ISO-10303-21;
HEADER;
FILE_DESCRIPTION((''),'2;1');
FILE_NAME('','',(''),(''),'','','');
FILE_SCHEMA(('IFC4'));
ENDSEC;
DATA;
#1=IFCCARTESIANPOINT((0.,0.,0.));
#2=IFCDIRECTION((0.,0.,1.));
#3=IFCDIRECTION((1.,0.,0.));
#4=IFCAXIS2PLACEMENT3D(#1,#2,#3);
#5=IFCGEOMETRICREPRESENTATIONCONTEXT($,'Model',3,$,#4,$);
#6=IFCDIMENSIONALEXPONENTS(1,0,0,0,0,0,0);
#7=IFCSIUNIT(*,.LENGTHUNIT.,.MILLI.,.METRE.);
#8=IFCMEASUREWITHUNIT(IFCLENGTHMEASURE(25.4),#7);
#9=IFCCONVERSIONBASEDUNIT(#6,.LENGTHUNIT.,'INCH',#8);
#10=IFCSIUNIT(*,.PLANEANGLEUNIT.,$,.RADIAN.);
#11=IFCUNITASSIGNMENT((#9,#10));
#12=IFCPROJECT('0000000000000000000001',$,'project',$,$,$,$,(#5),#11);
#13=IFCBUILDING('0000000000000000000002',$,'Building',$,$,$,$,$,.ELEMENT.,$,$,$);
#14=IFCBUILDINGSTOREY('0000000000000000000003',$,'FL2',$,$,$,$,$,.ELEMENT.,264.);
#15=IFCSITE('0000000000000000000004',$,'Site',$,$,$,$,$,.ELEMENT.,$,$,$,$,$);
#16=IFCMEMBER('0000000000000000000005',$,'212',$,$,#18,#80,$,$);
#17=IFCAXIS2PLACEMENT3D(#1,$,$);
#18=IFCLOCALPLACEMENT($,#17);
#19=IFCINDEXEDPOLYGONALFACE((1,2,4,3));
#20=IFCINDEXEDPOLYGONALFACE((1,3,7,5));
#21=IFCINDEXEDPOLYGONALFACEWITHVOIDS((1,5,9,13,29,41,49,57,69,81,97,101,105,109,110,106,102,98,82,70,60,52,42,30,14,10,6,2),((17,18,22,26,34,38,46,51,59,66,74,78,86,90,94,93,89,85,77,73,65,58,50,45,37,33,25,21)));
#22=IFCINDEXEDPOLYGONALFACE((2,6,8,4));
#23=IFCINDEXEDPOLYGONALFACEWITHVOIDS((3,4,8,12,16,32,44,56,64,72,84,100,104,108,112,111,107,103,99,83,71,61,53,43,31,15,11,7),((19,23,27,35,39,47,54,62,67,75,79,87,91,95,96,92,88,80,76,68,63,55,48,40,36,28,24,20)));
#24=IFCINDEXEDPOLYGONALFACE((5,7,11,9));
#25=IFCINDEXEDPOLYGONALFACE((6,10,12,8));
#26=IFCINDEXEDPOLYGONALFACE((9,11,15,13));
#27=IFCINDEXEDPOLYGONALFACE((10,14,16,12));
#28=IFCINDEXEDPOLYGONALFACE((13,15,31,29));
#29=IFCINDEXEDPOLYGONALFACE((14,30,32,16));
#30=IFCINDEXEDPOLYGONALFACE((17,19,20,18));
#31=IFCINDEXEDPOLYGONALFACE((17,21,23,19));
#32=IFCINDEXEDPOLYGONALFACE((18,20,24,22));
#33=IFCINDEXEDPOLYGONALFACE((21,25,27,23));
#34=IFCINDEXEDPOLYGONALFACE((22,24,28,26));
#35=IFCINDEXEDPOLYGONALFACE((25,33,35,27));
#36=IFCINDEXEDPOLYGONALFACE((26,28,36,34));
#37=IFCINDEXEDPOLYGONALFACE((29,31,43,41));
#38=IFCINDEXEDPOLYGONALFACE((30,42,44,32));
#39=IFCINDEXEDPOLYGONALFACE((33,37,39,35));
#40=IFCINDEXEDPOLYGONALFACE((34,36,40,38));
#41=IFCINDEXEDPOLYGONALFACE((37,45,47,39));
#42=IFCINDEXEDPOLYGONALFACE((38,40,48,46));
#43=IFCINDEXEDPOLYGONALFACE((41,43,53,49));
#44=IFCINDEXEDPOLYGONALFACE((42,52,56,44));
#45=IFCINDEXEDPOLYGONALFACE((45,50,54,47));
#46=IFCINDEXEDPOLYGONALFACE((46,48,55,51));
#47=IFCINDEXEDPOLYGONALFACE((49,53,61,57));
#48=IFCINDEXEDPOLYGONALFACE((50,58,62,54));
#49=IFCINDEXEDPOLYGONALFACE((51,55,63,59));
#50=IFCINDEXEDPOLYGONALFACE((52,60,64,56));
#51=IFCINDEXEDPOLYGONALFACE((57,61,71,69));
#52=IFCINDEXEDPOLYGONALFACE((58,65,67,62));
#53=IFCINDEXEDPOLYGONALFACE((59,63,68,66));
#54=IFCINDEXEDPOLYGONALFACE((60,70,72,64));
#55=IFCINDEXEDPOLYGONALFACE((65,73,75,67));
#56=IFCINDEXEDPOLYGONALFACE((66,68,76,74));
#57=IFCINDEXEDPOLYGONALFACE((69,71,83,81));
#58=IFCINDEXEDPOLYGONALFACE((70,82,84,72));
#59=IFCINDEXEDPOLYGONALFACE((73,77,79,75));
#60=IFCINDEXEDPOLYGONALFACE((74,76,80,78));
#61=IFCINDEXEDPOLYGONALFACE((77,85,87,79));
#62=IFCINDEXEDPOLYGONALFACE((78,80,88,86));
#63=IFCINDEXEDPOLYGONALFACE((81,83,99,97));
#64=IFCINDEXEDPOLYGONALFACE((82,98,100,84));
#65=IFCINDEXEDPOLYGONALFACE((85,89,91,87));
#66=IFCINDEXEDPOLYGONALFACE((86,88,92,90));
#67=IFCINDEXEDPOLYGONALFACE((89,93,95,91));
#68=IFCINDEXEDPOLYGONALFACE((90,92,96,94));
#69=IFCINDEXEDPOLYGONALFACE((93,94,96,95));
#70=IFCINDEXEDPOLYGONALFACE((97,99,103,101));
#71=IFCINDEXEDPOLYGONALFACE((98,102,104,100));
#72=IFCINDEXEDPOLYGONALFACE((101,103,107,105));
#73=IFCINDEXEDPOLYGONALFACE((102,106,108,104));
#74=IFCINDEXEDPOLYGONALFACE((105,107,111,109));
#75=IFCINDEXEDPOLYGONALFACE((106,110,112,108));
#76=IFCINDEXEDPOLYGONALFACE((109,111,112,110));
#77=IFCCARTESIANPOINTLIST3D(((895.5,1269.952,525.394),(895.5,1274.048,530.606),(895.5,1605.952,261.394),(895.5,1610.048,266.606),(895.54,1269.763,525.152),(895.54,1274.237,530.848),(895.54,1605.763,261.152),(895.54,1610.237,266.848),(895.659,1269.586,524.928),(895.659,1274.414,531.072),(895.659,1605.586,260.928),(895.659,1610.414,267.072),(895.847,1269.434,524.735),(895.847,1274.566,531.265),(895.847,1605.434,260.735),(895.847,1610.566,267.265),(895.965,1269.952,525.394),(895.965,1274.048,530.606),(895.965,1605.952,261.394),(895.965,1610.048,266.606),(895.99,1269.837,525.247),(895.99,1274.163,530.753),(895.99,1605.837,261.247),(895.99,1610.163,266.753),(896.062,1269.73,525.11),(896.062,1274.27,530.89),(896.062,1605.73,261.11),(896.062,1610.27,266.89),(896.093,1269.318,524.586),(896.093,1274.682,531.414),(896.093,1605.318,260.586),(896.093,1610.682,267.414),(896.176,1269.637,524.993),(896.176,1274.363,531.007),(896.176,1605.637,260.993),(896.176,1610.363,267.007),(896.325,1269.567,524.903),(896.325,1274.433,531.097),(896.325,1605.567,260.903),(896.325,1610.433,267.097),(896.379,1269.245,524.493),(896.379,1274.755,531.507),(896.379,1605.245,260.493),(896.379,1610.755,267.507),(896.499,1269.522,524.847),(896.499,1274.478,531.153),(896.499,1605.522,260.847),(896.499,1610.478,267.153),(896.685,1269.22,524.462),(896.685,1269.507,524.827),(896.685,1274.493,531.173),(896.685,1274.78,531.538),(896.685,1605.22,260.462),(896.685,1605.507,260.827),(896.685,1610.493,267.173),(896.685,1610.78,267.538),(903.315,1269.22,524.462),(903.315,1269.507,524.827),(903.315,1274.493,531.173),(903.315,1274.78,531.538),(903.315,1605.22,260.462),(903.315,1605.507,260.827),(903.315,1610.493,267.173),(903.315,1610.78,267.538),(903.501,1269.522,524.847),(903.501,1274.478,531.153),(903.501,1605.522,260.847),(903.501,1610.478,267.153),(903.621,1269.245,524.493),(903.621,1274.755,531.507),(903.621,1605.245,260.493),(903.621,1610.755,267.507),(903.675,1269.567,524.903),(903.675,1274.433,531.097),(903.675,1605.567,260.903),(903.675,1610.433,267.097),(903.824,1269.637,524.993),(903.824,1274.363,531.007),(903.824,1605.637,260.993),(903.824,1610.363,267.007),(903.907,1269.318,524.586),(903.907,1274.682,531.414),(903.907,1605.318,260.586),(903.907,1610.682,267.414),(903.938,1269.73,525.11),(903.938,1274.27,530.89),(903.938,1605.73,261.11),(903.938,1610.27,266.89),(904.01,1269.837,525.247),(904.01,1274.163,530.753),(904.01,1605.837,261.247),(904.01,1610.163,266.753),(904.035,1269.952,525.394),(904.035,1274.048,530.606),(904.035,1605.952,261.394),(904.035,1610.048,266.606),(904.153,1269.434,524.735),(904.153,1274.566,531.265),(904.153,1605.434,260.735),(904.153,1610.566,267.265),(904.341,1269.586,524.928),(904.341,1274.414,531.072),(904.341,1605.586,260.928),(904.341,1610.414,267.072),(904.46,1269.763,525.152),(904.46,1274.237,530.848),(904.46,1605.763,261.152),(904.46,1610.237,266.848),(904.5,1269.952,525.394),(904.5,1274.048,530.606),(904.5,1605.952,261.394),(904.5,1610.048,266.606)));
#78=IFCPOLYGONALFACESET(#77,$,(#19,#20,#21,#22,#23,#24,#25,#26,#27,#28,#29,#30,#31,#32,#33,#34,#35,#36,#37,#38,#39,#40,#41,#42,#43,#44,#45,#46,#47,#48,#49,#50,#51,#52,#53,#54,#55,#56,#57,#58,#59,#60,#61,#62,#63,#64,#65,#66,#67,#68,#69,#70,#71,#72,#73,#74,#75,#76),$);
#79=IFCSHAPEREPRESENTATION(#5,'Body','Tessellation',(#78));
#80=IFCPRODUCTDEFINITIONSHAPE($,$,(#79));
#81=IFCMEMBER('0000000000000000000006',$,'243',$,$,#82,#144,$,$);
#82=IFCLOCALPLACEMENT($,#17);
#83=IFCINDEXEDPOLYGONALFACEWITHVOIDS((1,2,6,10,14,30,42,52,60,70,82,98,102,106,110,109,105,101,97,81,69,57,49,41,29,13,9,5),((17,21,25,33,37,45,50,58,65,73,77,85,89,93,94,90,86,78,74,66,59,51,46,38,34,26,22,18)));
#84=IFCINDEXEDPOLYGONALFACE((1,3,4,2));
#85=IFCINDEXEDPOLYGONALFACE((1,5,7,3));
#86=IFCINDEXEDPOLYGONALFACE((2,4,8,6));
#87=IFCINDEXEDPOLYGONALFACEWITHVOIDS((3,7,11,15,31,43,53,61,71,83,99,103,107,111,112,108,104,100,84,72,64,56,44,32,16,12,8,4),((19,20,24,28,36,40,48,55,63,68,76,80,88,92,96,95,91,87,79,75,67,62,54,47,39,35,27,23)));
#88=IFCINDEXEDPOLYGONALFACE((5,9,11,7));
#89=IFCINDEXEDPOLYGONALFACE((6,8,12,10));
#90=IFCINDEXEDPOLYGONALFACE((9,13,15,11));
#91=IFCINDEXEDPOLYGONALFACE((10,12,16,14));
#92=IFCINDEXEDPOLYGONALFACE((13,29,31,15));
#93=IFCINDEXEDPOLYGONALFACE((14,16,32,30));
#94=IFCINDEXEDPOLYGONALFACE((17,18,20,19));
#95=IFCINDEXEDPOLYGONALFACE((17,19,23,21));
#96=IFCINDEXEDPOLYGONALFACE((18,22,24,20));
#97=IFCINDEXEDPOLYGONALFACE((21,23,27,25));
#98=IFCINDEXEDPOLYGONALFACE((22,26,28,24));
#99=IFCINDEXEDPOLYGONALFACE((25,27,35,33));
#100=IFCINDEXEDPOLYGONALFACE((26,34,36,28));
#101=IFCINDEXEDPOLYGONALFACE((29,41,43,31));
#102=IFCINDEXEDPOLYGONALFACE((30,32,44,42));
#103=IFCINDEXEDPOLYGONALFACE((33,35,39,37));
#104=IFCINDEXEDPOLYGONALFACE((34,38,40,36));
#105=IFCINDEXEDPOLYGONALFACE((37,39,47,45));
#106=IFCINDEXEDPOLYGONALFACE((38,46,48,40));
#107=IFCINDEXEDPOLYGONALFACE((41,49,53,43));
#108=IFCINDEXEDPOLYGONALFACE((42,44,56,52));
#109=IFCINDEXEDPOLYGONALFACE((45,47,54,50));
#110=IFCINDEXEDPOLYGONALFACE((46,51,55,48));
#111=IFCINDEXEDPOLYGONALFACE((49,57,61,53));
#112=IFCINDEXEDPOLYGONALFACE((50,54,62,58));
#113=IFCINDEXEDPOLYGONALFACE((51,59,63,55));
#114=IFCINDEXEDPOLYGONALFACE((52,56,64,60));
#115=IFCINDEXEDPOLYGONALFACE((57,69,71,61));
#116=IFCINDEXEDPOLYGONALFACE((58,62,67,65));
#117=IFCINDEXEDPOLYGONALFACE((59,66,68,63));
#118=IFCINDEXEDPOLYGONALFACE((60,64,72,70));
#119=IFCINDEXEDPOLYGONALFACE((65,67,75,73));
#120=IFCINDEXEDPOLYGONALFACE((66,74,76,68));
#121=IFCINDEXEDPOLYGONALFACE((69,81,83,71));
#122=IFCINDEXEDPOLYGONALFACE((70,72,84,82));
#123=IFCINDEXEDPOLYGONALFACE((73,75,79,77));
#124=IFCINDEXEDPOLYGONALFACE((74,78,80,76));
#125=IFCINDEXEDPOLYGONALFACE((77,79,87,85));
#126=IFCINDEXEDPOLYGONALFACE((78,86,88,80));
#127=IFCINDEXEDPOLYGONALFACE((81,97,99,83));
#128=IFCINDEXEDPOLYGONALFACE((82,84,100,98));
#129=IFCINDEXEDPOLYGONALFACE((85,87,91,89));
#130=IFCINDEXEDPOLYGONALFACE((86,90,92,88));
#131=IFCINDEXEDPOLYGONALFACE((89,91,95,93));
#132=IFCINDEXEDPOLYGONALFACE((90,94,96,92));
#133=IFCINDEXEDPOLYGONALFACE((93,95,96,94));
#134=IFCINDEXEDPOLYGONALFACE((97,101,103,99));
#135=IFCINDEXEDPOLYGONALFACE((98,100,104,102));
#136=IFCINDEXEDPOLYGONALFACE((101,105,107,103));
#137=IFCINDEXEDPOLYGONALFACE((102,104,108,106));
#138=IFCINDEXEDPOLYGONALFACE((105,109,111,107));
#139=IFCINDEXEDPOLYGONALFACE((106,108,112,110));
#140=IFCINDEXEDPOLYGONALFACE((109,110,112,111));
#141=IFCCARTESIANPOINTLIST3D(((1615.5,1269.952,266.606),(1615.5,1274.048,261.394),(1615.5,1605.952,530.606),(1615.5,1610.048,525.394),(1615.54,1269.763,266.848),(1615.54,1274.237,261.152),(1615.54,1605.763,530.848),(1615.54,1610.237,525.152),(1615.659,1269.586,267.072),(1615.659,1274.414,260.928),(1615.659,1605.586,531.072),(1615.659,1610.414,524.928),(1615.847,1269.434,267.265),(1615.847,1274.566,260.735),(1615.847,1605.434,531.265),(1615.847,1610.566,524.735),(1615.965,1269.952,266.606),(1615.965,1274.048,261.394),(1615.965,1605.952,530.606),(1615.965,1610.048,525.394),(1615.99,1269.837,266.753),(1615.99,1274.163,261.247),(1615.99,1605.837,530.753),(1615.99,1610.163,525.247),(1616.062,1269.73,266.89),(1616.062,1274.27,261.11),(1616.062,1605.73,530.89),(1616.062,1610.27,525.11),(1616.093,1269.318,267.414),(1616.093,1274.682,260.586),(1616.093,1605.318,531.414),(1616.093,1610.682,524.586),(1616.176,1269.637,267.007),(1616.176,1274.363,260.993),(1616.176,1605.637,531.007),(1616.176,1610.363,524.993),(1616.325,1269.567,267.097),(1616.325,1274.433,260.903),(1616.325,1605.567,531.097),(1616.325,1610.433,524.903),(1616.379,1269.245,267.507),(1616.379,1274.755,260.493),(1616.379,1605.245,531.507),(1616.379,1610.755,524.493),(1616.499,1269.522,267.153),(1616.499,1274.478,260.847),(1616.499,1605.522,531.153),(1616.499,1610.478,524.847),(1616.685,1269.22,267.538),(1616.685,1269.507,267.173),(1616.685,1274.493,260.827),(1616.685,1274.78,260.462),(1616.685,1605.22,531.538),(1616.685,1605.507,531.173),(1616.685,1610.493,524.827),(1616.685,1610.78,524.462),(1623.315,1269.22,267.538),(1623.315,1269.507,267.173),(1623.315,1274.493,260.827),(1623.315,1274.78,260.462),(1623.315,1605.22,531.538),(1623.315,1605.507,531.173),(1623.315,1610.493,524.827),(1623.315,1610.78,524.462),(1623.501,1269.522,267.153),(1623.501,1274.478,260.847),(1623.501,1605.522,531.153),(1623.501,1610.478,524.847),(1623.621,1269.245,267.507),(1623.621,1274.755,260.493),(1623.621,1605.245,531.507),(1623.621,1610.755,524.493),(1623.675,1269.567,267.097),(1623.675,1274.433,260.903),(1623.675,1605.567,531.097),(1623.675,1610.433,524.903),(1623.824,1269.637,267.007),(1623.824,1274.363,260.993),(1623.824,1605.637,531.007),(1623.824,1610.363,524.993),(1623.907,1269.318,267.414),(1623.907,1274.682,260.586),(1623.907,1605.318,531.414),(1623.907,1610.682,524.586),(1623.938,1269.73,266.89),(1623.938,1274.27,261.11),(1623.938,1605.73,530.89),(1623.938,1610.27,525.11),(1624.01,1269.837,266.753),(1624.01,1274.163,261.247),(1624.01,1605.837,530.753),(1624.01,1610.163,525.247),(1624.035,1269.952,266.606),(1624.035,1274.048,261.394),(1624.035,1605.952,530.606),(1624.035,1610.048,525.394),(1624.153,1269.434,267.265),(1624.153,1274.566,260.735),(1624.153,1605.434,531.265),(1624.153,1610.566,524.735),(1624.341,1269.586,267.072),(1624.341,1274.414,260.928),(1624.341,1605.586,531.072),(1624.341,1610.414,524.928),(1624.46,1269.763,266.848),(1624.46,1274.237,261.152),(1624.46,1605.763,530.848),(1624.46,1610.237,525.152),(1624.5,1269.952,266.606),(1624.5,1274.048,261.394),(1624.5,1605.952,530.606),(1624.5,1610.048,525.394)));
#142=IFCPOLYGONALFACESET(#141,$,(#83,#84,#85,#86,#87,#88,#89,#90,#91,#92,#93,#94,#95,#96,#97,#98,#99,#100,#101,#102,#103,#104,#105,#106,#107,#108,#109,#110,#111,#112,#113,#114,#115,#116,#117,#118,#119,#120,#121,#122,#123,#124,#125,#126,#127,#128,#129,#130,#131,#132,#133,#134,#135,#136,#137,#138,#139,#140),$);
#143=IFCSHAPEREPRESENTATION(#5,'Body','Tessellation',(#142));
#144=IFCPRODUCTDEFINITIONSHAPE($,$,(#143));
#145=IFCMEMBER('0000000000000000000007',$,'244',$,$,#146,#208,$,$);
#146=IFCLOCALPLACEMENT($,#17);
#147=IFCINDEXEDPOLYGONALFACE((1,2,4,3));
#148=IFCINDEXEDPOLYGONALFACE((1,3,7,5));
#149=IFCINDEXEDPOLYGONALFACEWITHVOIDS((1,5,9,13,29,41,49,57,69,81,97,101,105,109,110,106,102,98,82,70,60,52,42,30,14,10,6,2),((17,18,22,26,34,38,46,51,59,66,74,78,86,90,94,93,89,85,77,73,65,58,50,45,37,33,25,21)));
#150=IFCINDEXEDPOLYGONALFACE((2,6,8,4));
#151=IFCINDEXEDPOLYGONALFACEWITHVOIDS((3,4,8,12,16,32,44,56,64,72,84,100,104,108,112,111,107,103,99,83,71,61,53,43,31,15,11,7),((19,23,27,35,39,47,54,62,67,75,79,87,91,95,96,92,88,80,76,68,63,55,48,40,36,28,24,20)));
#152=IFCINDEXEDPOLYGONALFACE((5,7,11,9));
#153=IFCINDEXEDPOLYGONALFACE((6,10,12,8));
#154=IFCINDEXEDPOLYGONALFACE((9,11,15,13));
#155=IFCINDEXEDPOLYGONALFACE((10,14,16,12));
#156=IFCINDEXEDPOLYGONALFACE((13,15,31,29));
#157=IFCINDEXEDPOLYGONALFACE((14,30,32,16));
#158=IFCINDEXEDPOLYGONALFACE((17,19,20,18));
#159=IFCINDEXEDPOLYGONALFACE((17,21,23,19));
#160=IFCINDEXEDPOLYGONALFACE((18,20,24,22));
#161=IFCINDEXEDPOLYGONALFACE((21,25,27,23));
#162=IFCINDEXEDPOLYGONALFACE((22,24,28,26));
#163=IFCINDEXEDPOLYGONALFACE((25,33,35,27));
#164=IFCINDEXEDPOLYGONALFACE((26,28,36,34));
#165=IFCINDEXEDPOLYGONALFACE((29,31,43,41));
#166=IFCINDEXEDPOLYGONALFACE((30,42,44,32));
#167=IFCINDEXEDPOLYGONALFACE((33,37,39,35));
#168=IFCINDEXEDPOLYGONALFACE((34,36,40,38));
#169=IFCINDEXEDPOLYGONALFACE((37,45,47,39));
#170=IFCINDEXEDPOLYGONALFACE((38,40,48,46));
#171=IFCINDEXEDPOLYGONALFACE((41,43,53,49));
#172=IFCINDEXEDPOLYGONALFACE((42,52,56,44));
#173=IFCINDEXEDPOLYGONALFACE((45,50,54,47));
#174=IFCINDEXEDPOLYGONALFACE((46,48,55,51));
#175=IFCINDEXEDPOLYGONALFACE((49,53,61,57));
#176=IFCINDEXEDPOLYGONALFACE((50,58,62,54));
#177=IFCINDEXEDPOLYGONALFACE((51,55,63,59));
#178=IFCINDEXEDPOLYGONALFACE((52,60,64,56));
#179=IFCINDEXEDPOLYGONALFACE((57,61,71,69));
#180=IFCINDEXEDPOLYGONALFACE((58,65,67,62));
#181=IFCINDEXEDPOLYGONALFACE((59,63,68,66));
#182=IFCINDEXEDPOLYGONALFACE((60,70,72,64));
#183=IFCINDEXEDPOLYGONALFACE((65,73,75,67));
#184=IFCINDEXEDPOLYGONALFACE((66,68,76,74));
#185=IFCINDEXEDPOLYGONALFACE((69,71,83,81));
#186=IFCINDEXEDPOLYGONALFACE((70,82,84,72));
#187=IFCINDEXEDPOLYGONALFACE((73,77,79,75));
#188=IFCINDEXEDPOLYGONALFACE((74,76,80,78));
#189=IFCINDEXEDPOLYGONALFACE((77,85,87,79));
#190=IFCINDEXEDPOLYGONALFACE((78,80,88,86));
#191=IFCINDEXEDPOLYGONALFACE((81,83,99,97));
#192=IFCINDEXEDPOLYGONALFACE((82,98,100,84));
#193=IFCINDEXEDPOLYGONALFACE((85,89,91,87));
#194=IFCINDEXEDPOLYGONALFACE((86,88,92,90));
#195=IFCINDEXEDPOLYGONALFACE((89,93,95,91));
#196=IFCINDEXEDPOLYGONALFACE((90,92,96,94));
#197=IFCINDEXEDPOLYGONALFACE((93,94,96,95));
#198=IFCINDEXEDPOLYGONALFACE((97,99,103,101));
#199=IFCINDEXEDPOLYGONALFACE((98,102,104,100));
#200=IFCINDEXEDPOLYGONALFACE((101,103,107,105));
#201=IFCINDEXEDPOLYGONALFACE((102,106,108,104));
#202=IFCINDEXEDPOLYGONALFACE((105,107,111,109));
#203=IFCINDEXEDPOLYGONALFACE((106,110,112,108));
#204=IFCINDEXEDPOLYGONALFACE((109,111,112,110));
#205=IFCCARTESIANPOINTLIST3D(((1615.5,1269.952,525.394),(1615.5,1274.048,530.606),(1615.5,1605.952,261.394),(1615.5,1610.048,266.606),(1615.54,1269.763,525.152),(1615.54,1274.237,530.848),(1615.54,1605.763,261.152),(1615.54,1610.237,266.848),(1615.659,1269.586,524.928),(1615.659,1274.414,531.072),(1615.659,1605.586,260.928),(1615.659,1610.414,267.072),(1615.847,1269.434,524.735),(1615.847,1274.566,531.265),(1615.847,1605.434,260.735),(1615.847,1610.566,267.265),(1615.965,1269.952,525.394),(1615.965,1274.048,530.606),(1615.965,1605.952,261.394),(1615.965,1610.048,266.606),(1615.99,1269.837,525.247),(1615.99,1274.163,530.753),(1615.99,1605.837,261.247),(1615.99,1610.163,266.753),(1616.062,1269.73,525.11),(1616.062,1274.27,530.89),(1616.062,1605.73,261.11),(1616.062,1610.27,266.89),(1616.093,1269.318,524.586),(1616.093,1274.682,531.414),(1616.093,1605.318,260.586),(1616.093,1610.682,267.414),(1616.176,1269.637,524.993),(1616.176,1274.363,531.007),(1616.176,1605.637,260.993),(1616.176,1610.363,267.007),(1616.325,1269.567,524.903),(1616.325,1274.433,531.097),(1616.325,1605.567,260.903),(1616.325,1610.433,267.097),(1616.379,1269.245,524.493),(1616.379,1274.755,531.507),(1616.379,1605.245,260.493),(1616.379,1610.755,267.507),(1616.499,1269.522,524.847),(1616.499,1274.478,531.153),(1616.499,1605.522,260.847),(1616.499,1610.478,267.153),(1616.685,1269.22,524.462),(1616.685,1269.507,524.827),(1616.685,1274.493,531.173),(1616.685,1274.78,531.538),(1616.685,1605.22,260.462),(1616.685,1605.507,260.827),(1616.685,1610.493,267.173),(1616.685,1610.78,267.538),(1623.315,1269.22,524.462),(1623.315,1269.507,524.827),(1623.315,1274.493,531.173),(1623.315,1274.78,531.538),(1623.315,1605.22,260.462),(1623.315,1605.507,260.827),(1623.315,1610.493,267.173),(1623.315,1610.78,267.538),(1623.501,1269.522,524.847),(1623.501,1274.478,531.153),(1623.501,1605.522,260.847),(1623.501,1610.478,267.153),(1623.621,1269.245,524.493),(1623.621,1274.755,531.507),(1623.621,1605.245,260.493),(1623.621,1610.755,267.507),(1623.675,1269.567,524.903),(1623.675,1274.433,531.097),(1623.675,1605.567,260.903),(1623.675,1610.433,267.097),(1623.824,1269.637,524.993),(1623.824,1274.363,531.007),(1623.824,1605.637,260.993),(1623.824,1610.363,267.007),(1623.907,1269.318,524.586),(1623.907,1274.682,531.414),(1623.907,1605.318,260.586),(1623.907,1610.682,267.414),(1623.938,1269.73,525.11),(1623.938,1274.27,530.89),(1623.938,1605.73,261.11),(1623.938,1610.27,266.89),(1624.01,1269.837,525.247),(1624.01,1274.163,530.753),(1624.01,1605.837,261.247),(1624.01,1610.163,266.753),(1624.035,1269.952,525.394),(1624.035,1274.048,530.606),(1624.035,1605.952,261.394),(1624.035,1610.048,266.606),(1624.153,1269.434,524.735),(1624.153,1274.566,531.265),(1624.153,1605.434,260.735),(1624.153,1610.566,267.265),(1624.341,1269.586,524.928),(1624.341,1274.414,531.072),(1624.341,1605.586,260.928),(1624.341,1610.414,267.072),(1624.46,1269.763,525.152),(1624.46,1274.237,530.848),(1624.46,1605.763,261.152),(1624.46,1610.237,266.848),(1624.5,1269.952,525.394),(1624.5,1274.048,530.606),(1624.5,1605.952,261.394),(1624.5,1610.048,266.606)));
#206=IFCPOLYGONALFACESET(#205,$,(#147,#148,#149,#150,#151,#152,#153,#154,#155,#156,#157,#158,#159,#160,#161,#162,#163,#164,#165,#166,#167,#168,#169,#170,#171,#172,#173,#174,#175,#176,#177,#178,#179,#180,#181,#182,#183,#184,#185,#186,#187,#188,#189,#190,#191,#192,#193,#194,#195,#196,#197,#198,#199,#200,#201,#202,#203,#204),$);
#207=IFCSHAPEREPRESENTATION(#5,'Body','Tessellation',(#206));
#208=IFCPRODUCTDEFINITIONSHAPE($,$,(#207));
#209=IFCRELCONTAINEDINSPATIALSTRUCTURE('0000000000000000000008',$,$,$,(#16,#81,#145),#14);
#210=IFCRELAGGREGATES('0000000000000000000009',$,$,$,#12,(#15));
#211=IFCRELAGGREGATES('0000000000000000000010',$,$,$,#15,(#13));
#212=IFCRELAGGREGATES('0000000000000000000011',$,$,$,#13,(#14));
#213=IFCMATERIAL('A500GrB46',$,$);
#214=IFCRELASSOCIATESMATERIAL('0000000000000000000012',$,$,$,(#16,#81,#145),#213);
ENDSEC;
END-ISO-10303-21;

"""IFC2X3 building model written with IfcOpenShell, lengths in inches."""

from ifc_helpers import new_model, entity, si_unit, converted_unit, frame, origin_with_axes, origin_2d_with_axis, place, context, project, spatial, hollow_rectangle, extrude, material, element, save


model = new_model("IFC2X3")

# Units and contexts
model_context = context("Model", 3, world=origin_with_axes())
ifc_project = project(units=[converted_unit("LENGTHUNIT", "INCH", entity("IfcLengthMeasure", 25.4), si_unit("LENGTHUNIT", "METRE", prefix="MILLI"), dimensions=[1, 0, 0, 0, 0, 0, 0]), si_unit("PLANEANGLEUNIT", "RADIAN")], contexts=[model_context])

# Site, building, storey
site = spatial("IfcSite", under=ifc_project, Name="Site", CompositionType="ELEMENT")
building = spatial("IfcBuilding", under=site, Name="Building", CompositionType="ELEMENT")
storey = spatial("IfcBuildingStorey", under=building, Name="FL2", CompositionType="ELEMENT", Elevation=264.0)

# Members
ifc_material_1 = material(Name="A500GrB46")
for number, where, z_axis, x_axis, name in (
    (1, (900.0, 1608.0, 264.0), (0.0, -0.786318, 0.617822), (1.0, 0.0, 0.0), "212"),
    (2, (1620.0, 1272.0, 264.0), (0.0, 0.786318, 0.617822), (-1.0, 0.0, 0.0), "243"),
    (3, (1620.0, 1608.0, 264.0), (0.0, -0.786318, 0.617822), (1.0, 0.0, 0.0), "244"),
):
    element("IfcMember", number, at=place(None, frame(where, z_axis=z_axis, x_axis=x_axis)), inside=storey, material=ifc_material_1, Name=name, context=model_context, shape_type="SweptSolid", body=[
        extrude(hollow_rectangle(XDim=9.0, YDim=9.0, WallThickness=0.465, InnerFilletRadius=0.72, OuterFilletRadius=1.185, at=origin_2d_with_axis()), origin_with_axes(), (0.0, 0.0, 1.0), 427.308),
    ])

save(model, "model.ifc")
